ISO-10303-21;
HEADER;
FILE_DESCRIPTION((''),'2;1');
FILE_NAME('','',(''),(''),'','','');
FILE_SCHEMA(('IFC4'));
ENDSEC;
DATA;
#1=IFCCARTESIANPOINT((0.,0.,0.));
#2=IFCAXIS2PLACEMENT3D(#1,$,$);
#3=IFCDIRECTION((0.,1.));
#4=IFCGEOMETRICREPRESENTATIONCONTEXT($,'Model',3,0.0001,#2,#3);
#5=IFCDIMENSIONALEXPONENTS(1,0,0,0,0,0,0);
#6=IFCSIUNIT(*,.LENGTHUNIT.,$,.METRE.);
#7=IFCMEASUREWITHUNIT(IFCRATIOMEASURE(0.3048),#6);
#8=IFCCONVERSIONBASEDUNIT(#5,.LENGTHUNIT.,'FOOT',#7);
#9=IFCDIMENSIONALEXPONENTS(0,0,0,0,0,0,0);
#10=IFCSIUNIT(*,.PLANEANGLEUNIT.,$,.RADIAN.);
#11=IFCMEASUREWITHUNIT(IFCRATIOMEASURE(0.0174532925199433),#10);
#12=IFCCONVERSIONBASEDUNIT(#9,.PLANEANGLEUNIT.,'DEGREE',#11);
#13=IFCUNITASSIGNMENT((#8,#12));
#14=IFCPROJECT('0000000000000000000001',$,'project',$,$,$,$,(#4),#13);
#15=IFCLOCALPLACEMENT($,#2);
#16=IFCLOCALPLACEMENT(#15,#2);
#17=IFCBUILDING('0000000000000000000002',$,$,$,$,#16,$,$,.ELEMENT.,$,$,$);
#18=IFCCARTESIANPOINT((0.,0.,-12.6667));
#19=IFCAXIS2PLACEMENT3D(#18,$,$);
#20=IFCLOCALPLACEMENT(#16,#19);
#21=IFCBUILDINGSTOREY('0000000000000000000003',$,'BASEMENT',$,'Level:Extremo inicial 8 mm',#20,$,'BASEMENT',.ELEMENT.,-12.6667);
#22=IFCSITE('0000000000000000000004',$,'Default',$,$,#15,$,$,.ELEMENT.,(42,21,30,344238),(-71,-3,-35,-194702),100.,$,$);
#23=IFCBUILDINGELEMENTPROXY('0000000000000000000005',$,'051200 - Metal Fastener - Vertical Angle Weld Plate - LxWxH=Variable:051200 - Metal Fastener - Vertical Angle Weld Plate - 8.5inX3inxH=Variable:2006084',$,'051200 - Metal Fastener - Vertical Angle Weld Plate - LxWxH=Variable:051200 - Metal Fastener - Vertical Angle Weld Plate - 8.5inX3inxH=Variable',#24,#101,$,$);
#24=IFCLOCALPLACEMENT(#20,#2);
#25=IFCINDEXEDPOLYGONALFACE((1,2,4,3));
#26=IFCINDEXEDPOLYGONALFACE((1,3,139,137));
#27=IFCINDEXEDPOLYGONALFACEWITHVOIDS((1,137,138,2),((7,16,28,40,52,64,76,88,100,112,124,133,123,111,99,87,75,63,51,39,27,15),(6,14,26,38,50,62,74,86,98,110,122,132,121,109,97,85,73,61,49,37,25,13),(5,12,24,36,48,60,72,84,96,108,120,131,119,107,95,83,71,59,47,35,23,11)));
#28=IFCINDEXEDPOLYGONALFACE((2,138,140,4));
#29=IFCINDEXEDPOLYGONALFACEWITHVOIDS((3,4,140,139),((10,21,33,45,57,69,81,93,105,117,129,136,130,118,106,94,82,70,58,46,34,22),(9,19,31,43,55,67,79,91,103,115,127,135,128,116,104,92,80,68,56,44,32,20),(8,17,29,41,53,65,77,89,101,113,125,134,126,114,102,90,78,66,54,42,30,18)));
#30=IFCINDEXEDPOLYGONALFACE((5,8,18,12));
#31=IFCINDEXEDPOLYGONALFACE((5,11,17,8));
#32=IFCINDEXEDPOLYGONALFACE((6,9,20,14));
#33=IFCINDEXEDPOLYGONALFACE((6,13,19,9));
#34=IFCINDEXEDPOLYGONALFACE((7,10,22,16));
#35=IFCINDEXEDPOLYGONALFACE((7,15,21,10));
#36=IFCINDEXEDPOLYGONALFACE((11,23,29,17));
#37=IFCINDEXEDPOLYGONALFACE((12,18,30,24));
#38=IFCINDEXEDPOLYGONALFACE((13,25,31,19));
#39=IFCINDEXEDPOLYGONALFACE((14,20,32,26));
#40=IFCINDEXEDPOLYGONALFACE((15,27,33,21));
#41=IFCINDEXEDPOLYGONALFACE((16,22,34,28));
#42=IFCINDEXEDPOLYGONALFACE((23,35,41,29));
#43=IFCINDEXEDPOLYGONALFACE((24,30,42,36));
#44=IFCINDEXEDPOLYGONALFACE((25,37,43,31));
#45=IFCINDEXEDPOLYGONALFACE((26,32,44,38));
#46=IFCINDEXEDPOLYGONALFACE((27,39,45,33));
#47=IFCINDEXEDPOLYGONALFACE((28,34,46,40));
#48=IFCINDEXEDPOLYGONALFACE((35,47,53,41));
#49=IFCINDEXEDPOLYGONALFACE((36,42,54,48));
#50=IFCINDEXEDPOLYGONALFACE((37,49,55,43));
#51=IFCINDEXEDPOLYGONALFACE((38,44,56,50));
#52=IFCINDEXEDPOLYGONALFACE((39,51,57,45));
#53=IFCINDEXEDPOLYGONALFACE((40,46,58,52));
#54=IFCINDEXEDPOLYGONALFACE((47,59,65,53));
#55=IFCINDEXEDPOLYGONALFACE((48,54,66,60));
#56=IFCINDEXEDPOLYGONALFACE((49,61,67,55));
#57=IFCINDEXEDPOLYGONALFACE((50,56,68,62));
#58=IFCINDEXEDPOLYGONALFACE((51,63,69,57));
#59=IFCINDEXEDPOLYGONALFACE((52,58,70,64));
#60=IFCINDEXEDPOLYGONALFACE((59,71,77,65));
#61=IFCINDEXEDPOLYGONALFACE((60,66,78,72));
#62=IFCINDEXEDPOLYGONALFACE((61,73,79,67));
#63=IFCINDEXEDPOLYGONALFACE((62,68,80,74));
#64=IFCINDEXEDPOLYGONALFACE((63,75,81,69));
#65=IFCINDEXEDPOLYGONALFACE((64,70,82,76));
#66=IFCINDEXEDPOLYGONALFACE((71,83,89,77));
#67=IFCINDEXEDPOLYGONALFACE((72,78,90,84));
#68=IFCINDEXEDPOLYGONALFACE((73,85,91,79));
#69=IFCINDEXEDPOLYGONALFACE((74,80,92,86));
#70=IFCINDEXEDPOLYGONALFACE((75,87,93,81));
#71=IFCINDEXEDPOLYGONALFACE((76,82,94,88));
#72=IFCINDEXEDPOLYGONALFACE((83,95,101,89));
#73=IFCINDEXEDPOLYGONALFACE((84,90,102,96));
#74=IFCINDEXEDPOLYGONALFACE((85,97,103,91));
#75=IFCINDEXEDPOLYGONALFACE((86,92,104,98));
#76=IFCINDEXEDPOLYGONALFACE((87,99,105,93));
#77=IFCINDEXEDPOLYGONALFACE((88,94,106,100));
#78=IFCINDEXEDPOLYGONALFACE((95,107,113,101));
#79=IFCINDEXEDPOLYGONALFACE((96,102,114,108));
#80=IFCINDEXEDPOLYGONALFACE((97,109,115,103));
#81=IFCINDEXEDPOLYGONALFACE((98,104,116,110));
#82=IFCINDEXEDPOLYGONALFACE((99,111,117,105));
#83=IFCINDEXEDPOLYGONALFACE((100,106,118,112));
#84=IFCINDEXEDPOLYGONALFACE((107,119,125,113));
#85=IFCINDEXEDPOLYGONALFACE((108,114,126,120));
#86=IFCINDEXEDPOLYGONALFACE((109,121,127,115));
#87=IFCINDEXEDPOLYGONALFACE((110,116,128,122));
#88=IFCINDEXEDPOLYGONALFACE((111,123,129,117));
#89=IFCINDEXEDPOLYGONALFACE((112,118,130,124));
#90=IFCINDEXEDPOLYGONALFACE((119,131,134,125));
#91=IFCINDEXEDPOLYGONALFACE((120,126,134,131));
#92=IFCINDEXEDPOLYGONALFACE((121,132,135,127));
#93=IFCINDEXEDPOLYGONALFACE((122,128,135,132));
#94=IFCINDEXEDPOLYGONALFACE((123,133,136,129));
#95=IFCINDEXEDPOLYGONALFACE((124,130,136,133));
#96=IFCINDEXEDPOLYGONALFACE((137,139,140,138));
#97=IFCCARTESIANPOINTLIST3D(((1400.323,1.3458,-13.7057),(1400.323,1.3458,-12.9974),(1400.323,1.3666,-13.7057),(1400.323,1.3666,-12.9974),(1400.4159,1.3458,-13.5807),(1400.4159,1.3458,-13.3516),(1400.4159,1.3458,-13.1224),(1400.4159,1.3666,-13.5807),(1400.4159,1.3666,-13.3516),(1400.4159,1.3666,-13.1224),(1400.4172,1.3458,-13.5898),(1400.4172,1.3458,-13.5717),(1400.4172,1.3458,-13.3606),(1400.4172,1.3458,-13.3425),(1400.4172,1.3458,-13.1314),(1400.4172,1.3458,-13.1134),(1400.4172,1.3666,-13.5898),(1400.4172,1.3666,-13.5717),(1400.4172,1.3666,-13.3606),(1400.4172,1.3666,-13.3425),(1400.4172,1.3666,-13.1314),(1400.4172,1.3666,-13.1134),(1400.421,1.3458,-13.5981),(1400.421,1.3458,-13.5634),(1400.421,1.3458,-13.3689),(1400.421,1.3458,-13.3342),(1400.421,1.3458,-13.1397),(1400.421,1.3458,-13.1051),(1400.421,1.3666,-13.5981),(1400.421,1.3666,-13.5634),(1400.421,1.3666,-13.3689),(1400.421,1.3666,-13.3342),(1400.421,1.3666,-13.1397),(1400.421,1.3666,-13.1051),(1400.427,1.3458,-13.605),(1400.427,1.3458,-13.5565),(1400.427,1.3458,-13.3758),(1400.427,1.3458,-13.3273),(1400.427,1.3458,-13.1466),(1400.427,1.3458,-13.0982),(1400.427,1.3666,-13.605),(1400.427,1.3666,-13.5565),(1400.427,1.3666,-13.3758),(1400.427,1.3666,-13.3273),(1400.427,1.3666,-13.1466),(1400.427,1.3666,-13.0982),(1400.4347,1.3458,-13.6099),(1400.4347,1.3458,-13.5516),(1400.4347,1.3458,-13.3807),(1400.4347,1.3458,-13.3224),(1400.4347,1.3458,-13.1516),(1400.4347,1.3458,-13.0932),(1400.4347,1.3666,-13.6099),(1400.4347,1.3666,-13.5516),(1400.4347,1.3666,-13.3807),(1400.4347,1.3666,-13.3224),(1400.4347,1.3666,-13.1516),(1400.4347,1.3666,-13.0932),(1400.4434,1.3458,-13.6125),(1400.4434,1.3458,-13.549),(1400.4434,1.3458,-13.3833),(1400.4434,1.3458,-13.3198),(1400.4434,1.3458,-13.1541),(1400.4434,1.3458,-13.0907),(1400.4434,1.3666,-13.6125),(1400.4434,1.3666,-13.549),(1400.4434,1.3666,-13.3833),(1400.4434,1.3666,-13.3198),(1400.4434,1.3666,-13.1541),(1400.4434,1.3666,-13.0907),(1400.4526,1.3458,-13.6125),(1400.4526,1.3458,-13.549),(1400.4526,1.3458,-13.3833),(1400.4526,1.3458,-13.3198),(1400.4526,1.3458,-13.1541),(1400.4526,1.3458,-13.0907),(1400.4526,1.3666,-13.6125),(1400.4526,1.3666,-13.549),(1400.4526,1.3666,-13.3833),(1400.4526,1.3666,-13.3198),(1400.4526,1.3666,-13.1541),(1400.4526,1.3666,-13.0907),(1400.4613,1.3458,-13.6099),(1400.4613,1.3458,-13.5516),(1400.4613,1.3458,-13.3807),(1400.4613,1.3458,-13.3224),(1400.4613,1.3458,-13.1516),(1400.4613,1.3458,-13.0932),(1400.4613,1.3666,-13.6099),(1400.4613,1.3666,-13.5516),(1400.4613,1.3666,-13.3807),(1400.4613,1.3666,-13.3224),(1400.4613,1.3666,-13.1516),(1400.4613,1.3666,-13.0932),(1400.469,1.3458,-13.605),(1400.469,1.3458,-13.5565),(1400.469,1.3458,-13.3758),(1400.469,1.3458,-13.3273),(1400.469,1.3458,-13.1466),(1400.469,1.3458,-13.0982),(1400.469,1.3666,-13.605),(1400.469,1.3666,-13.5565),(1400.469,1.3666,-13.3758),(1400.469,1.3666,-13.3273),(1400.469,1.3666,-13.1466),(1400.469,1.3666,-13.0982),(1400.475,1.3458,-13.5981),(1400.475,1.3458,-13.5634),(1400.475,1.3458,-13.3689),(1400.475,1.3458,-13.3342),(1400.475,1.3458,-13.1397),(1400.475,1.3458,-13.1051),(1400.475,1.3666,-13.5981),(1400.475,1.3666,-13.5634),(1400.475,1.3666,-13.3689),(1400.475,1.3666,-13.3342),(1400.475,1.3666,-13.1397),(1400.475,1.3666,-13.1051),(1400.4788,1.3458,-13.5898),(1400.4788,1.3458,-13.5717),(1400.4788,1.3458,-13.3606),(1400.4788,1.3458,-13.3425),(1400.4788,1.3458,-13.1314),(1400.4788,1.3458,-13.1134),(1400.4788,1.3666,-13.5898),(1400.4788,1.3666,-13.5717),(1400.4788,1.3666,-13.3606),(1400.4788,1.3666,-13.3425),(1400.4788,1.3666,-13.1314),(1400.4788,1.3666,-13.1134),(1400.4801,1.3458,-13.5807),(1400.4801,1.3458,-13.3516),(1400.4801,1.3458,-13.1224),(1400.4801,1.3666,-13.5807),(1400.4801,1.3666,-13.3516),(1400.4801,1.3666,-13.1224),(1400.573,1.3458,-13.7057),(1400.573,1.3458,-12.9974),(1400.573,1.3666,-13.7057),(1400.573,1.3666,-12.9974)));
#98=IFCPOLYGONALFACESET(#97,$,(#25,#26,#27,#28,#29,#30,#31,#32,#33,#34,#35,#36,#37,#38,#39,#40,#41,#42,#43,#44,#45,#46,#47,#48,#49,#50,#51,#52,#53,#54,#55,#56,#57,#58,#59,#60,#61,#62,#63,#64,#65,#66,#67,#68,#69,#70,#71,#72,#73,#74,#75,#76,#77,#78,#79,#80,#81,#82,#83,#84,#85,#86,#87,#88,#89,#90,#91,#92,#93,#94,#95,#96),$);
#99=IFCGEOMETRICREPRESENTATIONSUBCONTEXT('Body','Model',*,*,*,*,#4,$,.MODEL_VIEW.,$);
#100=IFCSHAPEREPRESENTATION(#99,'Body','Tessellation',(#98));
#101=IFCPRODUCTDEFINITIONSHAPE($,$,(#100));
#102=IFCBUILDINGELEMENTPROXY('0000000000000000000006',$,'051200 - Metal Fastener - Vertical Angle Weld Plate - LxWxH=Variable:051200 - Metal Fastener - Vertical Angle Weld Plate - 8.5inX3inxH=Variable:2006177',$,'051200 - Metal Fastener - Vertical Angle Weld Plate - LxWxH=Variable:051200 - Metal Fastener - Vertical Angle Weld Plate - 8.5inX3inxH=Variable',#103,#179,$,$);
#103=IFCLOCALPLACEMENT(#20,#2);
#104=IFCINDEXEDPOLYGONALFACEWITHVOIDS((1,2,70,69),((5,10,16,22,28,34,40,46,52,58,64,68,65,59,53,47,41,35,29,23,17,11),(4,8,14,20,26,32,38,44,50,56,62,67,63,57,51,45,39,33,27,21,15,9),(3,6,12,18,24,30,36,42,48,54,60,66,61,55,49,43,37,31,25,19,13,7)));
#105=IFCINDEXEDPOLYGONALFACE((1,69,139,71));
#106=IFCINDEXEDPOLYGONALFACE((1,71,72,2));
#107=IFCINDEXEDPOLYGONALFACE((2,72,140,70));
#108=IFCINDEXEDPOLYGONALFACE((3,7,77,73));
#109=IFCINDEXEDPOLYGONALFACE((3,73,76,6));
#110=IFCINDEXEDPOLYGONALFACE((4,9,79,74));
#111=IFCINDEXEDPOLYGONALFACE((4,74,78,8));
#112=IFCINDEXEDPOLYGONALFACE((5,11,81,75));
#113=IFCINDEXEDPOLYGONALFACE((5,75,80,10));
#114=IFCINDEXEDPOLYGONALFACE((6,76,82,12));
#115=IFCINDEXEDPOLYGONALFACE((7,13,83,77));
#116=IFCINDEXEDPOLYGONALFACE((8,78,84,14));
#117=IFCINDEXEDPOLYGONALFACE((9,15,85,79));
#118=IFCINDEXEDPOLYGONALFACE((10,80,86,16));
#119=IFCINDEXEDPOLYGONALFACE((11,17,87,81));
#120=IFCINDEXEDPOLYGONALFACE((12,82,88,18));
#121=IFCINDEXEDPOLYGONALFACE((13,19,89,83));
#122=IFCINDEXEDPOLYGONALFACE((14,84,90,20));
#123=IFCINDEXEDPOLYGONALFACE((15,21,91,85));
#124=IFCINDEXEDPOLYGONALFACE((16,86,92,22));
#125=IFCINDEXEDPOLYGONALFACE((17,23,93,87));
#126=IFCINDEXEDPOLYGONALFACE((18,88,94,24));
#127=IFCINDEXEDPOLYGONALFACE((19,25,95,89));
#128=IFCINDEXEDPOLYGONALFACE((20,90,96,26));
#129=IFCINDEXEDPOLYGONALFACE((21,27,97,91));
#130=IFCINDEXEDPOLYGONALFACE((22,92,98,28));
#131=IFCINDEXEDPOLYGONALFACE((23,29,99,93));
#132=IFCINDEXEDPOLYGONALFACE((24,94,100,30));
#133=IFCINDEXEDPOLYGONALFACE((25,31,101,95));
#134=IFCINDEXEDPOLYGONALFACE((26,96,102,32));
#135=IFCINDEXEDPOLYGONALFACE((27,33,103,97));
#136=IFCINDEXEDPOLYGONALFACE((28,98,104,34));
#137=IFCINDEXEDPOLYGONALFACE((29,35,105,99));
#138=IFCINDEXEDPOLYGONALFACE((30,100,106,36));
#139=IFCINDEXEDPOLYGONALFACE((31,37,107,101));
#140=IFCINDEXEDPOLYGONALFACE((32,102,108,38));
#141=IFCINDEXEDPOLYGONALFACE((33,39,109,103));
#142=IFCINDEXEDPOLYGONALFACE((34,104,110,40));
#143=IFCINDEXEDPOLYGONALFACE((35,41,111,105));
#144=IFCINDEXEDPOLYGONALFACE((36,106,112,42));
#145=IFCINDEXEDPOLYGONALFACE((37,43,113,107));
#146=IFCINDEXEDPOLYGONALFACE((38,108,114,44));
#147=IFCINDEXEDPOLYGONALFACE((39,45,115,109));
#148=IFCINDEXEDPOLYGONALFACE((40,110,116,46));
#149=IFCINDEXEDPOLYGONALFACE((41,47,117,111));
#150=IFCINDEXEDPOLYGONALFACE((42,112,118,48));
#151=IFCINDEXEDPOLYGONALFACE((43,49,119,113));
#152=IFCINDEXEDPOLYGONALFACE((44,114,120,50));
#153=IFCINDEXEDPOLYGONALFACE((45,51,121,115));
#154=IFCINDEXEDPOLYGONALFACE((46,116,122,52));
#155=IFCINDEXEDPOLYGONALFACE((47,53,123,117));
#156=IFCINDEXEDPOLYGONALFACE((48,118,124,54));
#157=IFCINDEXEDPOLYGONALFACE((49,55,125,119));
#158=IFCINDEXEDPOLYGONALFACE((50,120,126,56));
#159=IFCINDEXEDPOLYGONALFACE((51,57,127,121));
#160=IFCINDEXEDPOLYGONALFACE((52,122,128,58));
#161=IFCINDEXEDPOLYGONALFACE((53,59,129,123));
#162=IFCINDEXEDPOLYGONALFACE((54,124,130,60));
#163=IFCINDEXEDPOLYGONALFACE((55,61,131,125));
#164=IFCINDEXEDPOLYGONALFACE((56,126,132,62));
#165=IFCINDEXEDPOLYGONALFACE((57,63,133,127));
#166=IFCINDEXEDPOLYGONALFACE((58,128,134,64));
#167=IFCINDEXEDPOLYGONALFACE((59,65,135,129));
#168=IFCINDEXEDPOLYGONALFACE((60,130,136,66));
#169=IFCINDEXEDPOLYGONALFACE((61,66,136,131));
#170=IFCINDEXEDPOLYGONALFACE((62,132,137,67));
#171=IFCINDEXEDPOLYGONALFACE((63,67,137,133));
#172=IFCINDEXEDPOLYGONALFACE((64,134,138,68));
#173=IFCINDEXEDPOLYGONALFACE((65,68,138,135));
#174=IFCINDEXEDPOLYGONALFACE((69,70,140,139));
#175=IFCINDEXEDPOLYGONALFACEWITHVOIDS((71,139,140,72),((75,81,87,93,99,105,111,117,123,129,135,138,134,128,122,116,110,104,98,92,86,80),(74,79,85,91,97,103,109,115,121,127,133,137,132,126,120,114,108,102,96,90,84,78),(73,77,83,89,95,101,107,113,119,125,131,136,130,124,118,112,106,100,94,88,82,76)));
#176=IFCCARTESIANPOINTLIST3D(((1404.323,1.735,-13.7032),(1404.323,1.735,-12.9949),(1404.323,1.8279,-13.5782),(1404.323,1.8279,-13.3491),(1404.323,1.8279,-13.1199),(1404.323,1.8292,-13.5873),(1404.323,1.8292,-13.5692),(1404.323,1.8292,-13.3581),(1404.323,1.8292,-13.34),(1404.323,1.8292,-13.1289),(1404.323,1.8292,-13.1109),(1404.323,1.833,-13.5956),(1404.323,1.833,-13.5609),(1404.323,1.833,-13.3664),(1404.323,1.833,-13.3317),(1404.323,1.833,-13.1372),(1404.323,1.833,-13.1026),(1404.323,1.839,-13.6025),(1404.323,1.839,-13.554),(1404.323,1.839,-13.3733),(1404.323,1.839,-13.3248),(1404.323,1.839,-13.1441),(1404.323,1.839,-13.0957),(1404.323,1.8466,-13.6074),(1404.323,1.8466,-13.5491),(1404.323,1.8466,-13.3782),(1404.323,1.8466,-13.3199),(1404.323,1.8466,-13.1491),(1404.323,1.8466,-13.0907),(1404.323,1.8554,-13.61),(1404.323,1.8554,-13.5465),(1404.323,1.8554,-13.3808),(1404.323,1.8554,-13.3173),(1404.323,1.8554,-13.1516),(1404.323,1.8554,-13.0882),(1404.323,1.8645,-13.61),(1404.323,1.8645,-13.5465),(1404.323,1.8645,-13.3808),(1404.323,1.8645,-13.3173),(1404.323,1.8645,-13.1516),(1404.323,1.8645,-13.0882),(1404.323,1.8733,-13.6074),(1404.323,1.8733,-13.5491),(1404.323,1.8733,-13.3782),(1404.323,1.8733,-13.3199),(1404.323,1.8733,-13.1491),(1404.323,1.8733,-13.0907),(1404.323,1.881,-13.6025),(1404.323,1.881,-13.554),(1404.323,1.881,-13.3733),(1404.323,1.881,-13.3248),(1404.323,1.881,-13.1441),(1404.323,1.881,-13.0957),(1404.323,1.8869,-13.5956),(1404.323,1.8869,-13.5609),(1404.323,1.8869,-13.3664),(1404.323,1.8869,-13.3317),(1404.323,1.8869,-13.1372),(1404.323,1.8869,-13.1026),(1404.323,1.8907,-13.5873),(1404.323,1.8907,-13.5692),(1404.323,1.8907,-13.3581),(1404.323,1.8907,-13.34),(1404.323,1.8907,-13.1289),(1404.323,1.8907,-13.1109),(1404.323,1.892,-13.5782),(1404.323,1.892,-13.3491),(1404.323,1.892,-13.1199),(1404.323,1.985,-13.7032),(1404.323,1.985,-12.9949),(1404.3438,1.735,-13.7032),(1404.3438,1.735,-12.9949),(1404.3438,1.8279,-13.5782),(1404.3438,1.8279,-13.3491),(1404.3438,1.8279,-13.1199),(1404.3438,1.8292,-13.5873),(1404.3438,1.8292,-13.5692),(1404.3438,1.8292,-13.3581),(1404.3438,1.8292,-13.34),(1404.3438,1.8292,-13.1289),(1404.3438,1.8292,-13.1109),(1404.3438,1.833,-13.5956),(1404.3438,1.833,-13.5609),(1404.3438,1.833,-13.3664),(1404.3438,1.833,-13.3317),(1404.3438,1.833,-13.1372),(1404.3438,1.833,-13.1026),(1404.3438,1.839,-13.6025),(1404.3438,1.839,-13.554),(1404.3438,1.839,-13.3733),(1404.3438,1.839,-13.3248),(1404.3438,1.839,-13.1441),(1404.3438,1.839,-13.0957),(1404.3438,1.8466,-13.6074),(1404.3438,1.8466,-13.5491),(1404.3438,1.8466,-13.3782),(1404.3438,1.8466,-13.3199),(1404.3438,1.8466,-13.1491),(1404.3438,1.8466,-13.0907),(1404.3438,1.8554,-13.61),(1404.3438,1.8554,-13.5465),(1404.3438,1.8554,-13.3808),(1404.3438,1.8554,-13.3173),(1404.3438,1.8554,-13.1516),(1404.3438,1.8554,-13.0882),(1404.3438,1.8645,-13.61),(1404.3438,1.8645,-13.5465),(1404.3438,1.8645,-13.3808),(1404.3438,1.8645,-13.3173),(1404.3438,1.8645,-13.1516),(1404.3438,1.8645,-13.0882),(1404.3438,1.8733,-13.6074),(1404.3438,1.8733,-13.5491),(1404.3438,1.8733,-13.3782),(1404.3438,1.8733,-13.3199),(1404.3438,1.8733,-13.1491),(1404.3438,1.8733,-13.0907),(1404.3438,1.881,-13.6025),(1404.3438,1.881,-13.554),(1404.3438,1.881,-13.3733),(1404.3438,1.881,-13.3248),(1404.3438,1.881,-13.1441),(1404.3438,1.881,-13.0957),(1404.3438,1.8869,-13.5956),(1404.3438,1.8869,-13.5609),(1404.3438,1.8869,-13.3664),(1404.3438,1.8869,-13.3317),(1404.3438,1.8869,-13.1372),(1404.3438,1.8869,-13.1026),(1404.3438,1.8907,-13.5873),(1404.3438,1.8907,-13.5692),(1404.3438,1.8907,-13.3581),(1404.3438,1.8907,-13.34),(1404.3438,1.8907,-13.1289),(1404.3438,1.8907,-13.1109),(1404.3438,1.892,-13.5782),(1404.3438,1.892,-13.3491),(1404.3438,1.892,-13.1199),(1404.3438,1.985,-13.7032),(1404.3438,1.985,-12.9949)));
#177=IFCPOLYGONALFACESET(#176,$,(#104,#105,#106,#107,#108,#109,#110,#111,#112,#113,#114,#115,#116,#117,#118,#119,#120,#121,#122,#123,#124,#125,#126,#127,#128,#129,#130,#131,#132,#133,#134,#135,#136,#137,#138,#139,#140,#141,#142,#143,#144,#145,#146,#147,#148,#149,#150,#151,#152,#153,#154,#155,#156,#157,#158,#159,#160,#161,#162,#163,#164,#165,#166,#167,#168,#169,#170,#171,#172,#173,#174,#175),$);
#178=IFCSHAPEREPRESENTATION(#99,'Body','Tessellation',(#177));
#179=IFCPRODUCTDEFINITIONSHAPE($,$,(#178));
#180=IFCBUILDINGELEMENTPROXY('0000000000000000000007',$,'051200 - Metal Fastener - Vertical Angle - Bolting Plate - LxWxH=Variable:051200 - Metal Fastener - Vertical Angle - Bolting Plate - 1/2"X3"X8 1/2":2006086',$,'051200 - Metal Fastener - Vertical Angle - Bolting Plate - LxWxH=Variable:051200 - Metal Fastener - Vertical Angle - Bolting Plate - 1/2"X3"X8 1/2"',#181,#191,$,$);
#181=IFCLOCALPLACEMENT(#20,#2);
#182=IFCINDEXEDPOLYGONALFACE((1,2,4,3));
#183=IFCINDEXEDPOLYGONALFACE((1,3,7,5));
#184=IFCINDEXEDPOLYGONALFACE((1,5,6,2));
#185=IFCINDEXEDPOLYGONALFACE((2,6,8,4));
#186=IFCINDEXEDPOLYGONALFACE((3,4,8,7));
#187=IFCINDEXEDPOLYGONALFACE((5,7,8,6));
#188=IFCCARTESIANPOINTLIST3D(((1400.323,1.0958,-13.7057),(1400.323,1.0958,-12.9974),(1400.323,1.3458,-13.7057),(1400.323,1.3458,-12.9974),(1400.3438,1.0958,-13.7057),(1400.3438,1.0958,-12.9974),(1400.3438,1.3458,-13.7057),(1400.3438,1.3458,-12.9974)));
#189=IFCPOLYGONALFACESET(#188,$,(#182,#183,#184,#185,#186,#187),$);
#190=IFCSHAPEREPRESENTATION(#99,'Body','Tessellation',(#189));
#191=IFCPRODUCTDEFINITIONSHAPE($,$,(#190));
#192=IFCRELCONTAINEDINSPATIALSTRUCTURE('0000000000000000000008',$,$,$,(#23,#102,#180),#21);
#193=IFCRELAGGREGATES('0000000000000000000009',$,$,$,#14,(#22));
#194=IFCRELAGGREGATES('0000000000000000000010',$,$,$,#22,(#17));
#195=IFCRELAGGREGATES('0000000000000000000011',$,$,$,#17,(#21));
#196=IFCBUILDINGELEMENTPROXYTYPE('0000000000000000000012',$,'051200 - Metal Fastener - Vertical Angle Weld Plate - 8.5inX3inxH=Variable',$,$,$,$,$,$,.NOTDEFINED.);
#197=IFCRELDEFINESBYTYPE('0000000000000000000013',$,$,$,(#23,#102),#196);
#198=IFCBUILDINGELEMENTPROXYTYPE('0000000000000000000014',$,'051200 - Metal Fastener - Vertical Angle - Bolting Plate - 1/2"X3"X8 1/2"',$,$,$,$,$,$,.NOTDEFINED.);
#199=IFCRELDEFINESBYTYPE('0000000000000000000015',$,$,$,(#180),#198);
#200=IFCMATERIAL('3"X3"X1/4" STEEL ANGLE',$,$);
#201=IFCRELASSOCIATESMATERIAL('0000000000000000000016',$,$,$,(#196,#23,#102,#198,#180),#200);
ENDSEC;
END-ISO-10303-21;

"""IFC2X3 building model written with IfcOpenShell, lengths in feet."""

from ifc_helpers import new_model, entity, si_unit, converted_unit, direction, frame, frame_2d, origin, origin_2d_with_axis, place, context, subcontext, project, spatial, polyline, circle_curve, parameter, trimmed, segment, composite_curve, rectangle, outline, extrude, source, transform, mapped, material, type_object, type_shapes, element, save


model = new_model("IFC2X3")

# Units and contexts
model_context = context("Model", 3, precision=0.0001, world=origin(), true_north=direction((0.0, 1.0)))
body_context = subcontext(model_context, "Body", "Model", "MODEL_VIEW")
ifc_project = project(units=[converted_unit("LENGTHUNIT", "FOOT", entity("IfcRatioMeasure", 0.3048), si_unit("LENGTHUNIT", "METRE"), dimensions=[1, 0, 0, 0, 0, 0, 0]), converted_unit("PLANEANGLEUNIT", "DEGREE", entity("IfcRatioMeasure", 0.0174532925199433), si_unit("PLANEANGLEUNIT", "RADIAN"), dimensions=[0, 0, 0, 0, 0, 0, 0])], contexts=[model_context])

# Site, building, storey
site_placement = place(None, origin())
site = spatial("IfcSite", under=ifc_project, at=site_placement, Name="Default", CompositionType="ELEMENT", RefLatitude=(42, 21, 30, 344238), RefLongitude=(-71, -3, -35, -194702), RefElevation=100.0)
building_placement = place(site_placement, origin())
building = spatial("IfcBuilding", under=site, at=building_placement, CompositionType="ELEMENT")
storey_placement = place(building_placement, frame((0.0, 0.0, -12.6667)))
storey = spatial("IfcBuildingStorey", under=building, at=storey_placement, Name="BASEMENT", ObjectType="Level:Extremo inicial 8 mm", LongName="BASEMENT", CompositionType="ELEMENT", Elevation=-12.6667)

# Building element proxies
ifc_material_1 = material(Name="3\"X3\"X1/4\" STEEL ANGLE")
building_element_proxy_type_1 = type_object("IfcBuildingElementProxyType", Name="051200 - Metal Fastener - Vertical Angle Weld Plate - 8.5inX3inxH=Variable", PredefinedType="NOTDEFINED", material=ifc_material_1)
shared_shape_1 = source(origin(), body_context, "Body", "SweptSolid", [
    extrude(outline(polyline([(-0.125, -0.3542), (0.125, -0.3542), (0.125, 0.3542), (-0.125, 0.3542), (-0.125, -0.3542)]), holes=[composite_curve([segment(trimmed(circle_curve(frame_2d((0.0, -0.2292), x_axis=(-1.0, 0.0)), 0.0321), [parameter(180.0)], [parameter(0.0)], True, "PARAMETER"), False, "CONTINUOUS"), segment(trimmed(circle_curve(frame_2d((0.0, -0.2292), x_axis=(-1.0, 0.0)), 0.0321), [parameter(0.0)], [parameter(180.0)], True, "PARAMETER"), False, "CONTINUOUS")], self_intersect=False), composite_curve([segment(trimmed(circle_curve(frame_2d((0.0, 0.0), x_axis=(-1.0, 0.0)), 0.0321), [parameter(180.0)], [parameter(0.0)], True, "PARAMETER"), False, "CONTINUOUS"), segment(trimmed(circle_curve(frame_2d((0.0, 0.0), x_axis=(-1.0, 0.0)), 0.0321), [parameter(0.0)], [parameter(180.0)], True, "PARAMETER"), False, "CONTINUOUS")], self_intersect=False), composite_curve([segment(trimmed(circle_curve(frame_2d((0.0, 0.2292), x_axis=(-1.0, 0.0)), 0.0321), [parameter(180.0)], [parameter(0.0)], True, "PARAMETER"), False, "CONTINUOUS"), segment(trimmed(circle_curve(frame_2d((0.0, 0.2292), x_axis=(-1.0, 0.0)), 0.0321), [parameter(0.0)], [parameter(180.0)], True, "PARAMETER"), False, "CONTINUOUS")], self_intersect=False)]), frame((0.0, 0.0, 0.0), z_axis=(0.0, 0.0, 1.0), x_axis=(-1.0, 0.0, 0.0)), (0.0, 0.0, 1.0), 0.0208),
])
type_shapes(building_element_proxy_type_1, [shared_shape_1])
for number, where, z_axis, x_axis, name in (
    (1, (1400.448, 1.3666, -13.3516), (0.0, -1.0, 0.0), (1.0, 0.0, 0.0), "051200 - Metal Fastener - Vertical Angle Weld Plate - LxWxH=Variable:051200 - Metal Fastener - Vertical Angle Weld Plate - 8.5inX3inxH=Variable:2006084"),
    (2, (1404.323, 1.86, -13.3491), (1.0, 0.0, 0.0), (0.0, 1.0, 0.0), "051200 - Metal Fastener - Vertical Angle Weld Plate - LxWxH=Variable:051200 - Metal Fastener - Vertical Angle Weld Plate - 8.5inX3inxH=Variable:2006177"),
):
    element("IfcBuildingElementProxy", number, at=place(storey_placement, frame(where, z_axis=z_axis, x_axis=x_axis)), inside=storey, type_object=building_element_proxy_type_1, material=ifc_material_1, Name=name, ObjectType="051200 - Metal Fastener - Vertical Angle Weld Plate - LxWxH=Variable:051200 - Metal Fastener - Vertical Angle Weld Plate - 8.5inX3inxH=Variable", context=body_context, shape_type="MappedRepresentation", body=[
        mapped(shared_shape_1, transform((0.0, 0.0, 0.0), scale=1.0)),
    ])
building_element_proxy_type_2 = type_object("IfcBuildingElementProxyType", Name="051200 - Metal Fastener - Vertical Angle - Bolting Plate - 1/2\"X3\"X8 1/2\"", PredefinedType="NOTDEFINED", material=ifc_material_1)
shared_shape_2 = source(origin(), body_context, "Body", "SweptSolid", [
    extrude(rectangle(XDim=0.25, YDim=0.7083, at=origin_2d_with_axis()), frame((0.0, 0.0, 0.0), z_axis=(0.0, 0.0, 1.0), x_axis=(-1.0, 0.0, 0.0)), (0.0, 0.0, 1.0), 0.0208),
])
type_shapes(building_element_proxy_type_2, [shared_shape_2])
for number, where, z_axis, x_axis, name in (
    (3, (1400.323, 1.2208, -13.3516), (1.0, 0.0, 0.0), (0.0, 1.0, 0.0), "051200 - Metal Fastener - Vertical Angle - Bolting Plate - LxWxH=Variable:051200 - Metal Fastener - Vertical Angle - Bolting Plate - 1/2\"X3\"X8 1/2\":2006086"),
):
    element("IfcBuildingElementProxy", number, at=place(storey_placement, frame(where, z_axis=z_axis, x_axis=x_axis)), inside=storey, type_object=building_element_proxy_type_2, material=ifc_material_1, Name=name, ObjectType="051200 - Metal Fastener - Vertical Angle - Bolting Plate - LxWxH=Variable:051200 - Metal Fastener - Vertical Angle - Bolting Plate - 1/2\"X3\"X8 1/2\"", context=body_context, shape_type="MappedRepresentation", body=[
        mapped(shared_shape_2, transform((0.0, 0.0, 0.0), scale=1.0)),
    ])

save(model, "model.ifc")
